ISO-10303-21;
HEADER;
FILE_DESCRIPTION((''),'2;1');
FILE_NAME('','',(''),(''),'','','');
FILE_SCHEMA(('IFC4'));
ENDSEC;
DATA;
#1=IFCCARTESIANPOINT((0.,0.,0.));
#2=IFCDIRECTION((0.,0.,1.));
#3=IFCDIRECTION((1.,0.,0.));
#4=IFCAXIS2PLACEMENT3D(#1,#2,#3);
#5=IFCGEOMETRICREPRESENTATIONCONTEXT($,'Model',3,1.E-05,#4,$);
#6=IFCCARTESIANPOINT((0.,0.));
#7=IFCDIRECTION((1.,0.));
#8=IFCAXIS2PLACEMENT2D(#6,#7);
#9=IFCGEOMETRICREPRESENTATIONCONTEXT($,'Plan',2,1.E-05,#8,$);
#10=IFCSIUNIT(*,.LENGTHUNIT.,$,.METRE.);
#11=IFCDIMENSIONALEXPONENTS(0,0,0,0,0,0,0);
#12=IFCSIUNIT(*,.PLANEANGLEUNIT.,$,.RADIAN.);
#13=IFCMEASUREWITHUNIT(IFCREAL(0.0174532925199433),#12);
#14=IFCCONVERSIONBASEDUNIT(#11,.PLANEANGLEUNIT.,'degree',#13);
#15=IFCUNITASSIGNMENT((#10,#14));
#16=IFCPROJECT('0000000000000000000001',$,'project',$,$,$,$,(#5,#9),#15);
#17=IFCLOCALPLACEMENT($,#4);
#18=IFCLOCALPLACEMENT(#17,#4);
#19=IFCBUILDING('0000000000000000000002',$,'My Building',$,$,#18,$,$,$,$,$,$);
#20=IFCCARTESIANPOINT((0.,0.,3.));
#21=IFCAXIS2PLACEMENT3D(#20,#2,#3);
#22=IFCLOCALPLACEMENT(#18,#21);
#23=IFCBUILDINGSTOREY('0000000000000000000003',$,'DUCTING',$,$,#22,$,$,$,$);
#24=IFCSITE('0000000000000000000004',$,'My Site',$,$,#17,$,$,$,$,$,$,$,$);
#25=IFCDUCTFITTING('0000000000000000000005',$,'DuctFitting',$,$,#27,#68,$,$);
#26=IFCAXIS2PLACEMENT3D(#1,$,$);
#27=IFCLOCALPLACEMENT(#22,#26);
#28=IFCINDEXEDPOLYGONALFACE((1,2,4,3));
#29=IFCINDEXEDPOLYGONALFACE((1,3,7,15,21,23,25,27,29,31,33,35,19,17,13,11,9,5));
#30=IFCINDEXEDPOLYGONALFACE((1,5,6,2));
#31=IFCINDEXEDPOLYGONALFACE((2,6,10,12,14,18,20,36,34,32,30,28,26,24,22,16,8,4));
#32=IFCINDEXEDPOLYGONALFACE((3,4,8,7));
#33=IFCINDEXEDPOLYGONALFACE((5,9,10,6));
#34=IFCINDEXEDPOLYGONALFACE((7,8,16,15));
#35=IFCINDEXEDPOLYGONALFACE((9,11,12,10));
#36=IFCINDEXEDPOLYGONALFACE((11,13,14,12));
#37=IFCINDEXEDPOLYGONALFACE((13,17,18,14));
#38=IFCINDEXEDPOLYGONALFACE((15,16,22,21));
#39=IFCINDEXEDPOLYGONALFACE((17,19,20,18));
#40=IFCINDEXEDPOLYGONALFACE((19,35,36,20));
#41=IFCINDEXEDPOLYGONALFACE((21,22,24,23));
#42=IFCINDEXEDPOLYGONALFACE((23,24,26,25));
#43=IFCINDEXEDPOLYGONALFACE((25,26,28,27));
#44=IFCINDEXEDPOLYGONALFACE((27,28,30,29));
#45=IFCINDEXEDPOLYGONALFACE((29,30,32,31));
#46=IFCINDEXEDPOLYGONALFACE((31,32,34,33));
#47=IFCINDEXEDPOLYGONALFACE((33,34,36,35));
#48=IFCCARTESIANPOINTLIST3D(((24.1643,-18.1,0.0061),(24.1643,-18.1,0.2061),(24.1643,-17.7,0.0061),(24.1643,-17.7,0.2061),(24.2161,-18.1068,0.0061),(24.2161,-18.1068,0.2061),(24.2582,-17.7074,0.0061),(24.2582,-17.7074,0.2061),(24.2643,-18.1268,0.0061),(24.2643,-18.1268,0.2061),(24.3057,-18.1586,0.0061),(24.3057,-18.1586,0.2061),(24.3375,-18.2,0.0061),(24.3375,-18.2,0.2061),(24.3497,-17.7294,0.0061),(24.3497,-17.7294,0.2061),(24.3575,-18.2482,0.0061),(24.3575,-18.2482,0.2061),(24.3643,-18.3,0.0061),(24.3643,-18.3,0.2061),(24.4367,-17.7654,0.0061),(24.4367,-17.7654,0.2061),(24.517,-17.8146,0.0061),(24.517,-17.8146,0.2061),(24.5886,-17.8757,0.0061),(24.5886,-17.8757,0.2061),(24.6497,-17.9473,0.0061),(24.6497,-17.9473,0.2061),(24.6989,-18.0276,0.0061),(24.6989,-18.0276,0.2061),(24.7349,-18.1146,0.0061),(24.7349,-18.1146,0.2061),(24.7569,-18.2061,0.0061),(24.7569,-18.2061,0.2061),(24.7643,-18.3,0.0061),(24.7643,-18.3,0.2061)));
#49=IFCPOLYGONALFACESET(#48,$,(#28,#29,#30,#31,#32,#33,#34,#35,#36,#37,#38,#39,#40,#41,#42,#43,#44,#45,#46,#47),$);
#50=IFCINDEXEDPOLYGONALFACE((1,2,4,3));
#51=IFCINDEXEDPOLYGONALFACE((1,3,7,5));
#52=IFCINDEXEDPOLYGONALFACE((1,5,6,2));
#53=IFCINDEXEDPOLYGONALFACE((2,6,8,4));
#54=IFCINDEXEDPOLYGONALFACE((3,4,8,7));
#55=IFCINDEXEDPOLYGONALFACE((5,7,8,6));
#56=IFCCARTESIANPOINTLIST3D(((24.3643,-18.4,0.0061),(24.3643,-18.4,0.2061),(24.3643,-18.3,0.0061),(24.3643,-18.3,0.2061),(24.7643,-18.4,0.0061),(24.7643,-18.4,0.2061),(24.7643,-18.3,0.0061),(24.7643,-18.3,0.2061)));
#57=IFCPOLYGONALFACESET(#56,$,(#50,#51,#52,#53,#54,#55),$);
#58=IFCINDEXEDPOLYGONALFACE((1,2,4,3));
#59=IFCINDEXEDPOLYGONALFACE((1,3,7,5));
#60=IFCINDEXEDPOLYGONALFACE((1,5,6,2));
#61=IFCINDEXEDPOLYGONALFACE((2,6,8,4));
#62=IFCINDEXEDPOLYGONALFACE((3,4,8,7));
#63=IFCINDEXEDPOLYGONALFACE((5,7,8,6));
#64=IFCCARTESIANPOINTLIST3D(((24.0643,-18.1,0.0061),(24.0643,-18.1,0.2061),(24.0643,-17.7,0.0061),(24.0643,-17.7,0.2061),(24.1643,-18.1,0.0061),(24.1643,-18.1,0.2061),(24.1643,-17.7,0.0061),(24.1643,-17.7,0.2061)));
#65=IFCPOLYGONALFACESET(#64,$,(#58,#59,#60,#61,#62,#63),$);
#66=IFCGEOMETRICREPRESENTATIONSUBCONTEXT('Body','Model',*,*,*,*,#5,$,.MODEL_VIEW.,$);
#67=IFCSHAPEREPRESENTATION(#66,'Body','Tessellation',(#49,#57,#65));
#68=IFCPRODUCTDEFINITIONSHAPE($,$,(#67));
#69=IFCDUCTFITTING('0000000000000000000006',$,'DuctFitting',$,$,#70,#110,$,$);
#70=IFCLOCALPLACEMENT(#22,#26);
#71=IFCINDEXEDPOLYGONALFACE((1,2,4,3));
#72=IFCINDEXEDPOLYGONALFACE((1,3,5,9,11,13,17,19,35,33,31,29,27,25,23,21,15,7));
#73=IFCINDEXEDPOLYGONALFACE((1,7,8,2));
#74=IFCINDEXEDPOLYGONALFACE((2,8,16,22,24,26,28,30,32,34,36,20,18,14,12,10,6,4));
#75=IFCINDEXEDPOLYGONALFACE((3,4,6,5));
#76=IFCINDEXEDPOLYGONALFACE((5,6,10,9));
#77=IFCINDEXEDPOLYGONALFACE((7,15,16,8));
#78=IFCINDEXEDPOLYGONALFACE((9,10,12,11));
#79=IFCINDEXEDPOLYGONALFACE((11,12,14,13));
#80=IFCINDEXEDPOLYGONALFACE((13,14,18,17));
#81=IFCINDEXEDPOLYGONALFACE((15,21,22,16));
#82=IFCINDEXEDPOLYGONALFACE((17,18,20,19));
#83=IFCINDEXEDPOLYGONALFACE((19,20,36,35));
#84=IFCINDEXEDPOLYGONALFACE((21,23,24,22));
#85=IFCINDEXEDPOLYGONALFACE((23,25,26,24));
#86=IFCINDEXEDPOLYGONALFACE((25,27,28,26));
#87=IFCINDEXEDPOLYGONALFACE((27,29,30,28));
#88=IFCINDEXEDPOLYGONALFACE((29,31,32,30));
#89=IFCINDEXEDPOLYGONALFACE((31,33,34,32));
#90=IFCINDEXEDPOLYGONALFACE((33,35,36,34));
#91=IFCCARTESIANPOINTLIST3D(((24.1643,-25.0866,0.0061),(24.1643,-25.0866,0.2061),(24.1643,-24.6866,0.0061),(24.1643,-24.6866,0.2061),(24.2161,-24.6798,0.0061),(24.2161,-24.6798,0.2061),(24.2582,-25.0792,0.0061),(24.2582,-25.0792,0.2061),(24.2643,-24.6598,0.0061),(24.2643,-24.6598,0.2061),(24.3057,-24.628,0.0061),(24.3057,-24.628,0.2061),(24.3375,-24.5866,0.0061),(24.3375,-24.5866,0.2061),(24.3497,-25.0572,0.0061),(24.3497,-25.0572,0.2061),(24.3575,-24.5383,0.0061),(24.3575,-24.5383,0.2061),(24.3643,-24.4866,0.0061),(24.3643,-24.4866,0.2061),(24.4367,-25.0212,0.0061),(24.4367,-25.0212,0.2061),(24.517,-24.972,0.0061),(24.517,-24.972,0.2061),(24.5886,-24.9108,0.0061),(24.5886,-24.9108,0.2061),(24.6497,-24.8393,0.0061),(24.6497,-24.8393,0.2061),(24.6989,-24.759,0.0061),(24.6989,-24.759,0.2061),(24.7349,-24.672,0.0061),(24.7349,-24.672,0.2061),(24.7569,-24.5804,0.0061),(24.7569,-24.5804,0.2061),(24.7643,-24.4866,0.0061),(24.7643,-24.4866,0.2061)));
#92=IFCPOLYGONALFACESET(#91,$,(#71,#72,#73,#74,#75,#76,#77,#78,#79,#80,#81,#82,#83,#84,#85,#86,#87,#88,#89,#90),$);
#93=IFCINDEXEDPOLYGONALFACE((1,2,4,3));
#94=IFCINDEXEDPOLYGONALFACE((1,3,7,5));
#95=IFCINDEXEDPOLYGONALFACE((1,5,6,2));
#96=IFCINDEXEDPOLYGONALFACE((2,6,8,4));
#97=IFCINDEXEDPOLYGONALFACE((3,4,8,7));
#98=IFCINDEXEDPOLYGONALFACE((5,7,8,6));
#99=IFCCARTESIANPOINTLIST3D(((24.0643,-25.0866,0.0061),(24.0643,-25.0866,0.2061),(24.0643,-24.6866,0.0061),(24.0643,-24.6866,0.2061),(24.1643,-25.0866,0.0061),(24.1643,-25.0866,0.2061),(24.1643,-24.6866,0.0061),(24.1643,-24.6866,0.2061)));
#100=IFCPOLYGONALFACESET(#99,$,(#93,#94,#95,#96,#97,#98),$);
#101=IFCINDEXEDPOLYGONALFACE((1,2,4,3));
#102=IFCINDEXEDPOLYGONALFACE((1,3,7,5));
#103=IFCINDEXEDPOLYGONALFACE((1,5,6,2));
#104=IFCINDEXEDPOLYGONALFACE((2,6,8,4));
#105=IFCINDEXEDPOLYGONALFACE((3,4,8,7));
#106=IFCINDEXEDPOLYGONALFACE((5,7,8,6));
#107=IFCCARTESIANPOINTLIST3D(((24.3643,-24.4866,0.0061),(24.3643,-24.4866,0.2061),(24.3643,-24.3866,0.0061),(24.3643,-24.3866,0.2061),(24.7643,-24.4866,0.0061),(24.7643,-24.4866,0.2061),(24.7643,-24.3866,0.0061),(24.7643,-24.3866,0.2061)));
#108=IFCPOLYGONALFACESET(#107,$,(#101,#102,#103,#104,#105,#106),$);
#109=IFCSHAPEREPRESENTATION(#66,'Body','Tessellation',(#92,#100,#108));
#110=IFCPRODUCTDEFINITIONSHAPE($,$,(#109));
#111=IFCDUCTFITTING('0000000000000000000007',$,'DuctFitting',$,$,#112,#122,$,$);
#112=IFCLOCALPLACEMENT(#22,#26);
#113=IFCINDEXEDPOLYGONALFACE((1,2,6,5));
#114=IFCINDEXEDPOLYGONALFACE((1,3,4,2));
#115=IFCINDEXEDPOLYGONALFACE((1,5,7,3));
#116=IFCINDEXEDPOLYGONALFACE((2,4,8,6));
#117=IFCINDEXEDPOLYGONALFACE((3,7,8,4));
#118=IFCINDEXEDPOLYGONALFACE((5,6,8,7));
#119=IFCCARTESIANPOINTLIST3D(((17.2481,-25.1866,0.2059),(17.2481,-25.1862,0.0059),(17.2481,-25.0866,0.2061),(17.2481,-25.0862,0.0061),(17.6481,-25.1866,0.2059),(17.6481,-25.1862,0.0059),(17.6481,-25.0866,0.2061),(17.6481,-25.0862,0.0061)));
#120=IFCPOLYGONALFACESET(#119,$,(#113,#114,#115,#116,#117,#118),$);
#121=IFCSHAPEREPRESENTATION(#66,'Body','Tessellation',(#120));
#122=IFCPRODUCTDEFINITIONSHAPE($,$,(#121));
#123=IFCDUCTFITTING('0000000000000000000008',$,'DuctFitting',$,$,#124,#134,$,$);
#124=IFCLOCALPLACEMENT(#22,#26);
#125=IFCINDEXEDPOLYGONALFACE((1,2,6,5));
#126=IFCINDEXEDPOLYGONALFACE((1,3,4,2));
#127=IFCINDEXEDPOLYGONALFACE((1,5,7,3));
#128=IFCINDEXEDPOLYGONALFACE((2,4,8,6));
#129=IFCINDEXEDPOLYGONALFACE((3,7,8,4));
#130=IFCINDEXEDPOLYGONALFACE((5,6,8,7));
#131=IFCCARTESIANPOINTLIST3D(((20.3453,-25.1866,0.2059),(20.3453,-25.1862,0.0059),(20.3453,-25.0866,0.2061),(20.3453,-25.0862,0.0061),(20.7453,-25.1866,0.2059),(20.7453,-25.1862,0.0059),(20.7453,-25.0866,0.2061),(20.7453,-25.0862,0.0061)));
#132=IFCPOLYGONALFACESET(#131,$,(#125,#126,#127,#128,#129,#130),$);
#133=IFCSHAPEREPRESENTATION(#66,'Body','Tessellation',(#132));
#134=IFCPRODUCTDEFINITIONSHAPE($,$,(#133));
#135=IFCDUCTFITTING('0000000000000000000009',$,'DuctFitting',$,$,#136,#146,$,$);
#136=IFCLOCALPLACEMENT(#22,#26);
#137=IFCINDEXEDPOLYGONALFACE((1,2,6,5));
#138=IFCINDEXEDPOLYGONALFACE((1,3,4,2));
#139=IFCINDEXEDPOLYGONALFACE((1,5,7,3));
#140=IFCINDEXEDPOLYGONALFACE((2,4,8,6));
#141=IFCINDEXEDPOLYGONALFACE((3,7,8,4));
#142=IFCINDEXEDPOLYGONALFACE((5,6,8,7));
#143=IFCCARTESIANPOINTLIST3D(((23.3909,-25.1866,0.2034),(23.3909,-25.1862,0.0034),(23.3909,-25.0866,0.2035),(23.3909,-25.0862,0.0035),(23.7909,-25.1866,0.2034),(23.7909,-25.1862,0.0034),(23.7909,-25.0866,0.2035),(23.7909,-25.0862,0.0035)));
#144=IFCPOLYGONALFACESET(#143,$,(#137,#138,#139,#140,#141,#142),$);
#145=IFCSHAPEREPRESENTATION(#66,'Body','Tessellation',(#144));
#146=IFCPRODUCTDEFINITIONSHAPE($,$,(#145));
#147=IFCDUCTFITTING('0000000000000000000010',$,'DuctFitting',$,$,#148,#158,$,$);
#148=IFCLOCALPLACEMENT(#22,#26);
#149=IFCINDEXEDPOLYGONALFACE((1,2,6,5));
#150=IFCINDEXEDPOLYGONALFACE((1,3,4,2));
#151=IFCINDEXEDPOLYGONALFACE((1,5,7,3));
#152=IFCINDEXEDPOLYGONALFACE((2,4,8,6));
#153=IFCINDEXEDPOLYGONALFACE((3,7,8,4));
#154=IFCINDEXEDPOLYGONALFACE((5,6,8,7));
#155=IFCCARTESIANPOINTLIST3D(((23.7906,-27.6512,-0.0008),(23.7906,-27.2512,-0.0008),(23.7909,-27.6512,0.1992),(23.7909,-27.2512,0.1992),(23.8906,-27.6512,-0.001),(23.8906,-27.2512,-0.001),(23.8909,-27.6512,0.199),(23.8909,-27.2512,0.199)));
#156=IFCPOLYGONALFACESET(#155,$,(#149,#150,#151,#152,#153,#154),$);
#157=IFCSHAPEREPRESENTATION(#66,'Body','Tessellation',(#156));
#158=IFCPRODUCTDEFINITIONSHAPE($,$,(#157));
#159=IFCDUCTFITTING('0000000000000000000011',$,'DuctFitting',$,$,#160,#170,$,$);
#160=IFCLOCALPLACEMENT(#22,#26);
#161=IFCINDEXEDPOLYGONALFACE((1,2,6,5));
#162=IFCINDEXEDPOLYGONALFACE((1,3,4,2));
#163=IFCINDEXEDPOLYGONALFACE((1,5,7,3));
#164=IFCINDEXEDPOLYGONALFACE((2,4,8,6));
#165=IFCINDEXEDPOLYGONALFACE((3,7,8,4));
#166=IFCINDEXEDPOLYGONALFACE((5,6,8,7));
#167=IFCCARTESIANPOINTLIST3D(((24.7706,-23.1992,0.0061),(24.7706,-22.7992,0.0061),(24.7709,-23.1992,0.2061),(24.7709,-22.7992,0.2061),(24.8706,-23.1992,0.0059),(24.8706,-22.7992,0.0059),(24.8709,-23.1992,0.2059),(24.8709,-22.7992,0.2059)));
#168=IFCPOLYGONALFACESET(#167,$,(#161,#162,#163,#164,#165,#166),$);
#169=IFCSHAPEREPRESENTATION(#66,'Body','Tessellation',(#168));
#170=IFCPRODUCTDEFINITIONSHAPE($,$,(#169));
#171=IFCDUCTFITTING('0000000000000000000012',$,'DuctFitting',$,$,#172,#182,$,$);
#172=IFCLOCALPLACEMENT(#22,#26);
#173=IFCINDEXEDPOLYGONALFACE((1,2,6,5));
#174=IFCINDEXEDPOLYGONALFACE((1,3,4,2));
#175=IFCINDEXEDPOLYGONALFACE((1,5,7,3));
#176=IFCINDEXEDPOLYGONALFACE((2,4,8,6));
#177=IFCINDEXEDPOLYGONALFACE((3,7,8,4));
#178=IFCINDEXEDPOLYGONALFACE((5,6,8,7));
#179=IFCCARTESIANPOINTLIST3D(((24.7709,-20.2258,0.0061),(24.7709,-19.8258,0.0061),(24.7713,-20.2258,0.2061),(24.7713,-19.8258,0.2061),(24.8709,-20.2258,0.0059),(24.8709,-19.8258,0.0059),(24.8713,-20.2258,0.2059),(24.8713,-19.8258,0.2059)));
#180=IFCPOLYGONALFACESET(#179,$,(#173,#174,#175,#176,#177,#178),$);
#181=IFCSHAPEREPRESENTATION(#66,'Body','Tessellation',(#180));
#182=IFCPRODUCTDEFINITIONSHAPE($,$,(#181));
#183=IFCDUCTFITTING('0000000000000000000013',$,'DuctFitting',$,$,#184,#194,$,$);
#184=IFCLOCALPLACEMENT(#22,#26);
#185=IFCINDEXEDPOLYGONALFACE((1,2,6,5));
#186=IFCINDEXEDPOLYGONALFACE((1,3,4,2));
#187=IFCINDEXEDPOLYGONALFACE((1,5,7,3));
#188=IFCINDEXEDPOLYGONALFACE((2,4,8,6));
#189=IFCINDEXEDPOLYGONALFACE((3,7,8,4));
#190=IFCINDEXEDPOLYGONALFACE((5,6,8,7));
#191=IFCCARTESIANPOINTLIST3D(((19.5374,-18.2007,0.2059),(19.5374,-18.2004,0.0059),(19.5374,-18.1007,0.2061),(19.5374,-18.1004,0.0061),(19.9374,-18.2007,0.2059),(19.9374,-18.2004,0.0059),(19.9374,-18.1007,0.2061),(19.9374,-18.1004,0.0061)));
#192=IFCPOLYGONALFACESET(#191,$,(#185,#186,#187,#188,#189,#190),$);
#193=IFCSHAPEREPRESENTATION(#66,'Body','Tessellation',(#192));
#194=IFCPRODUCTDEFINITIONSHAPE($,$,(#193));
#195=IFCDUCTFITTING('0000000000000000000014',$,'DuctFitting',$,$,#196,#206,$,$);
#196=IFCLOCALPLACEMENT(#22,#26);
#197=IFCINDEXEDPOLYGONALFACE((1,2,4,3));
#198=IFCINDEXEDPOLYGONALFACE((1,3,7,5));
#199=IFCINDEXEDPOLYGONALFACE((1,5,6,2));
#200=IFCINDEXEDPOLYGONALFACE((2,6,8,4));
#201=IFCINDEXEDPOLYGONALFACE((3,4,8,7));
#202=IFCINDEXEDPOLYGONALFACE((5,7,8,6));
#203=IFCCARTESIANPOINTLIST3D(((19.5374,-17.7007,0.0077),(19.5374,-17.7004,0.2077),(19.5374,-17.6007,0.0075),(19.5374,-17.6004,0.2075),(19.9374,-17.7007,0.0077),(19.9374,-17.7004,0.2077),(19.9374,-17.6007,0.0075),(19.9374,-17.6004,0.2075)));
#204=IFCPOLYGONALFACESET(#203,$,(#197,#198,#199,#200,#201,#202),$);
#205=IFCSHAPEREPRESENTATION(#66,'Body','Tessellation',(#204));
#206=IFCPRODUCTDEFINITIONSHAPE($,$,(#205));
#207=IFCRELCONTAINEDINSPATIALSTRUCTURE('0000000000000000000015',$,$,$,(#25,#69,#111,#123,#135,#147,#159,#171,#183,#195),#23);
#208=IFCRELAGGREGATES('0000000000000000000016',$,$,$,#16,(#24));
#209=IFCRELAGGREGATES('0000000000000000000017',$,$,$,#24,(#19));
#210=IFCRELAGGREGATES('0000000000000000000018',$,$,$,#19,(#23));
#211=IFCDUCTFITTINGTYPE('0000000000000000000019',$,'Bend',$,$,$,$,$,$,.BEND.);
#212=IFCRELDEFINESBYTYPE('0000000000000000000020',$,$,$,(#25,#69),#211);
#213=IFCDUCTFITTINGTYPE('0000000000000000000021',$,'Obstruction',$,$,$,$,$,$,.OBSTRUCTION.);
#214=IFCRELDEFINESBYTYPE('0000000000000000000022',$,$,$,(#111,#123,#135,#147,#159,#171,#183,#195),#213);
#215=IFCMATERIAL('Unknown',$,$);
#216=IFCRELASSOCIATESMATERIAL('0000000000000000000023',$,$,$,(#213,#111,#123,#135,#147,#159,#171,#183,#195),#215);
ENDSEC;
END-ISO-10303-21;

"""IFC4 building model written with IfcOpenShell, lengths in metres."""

from ifc_helpers import new_model, entity, si_unit, converted_unit, frame, origin_with_axes, origin_2d_with_axis, place, context, subcontext, project, spatial, line, arc, indexed_curve, rectangle, outline, extrude, source, transform, mapped, material, material_profile, profile_set, profile_usage, type_object, type_shapes, element, save


model = new_model("IFC4")

# Units and contexts
model_context = context("Model", 3, precision=1e-05, world=origin_with_axes())
plan_context = context("Plan", 2, precision=1e-05, world=origin_2d_with_axis())
body_context = subcontext(model_context, "Body", "Model", "MODEL_VIEW")
ifc_project = project(units=[si_unit("LENGTHUNIT", "METRE"), converted_unit("PLANEANGLEUNIT", "degree", entity("IfcReal", 0.0174532925199433), si_unit("PLANEANGLEUNIT", "RADIAN"), dimensions=[0, 0, 0, 0, 0, 0, 0])], contexts=[model_context, plan_context])

# Site, building, storey
site_placement = place(None, origin_with_axes())
site = spatial("IfcSite", under=ifc_project, at=site_placement, Name="My Site")
building_placement = place(site_placement, origin_with_axes())
building = spatial("IfcBuilding", under=site, at=building_placement, Name="My Building")
storey_placement = place(building_placement, frame((0.0, 0.0, 3.0), z_axis=(0.0, 0.0, 1.0), x_axis=(1.0, 0.0, 0.0)))
storey = spatial("IfcBuildingStorey", under=building, at=storey_placement, Name="DUCTING")

# Shared definitions
ifc_material = material(Name="Unknown")

# Duct fittings
duct_fitting_type_1 = type_object("IfcDuctFittingType", Name="Bend", PredefinedType="BEND")
shared_shape = source(origin_with_axes(), body_context, "Body", "SweptSolid", [
    extrude(outline(indexed_curve([(-0.2, 0.0), (-0.2586, -0.1414), (-0.4, -0.2), (-0.4, -0.6), (0.0243, -0.4243), (0.2, 0.0)], segments=[arc(1, 2, 3), line(3, 4), arc(4, 5, 6), line(6, 1)])), frame((0.0, -0.1, -0.1), z_axis=(0.0, -1.0, 0.0), x_axis=(1.0, 0.0, 0.0)), (0.0, 0.0, -1.0), 0.2),
    extrude(rectangle(XDim=0.4, YDim=0.2), origin_with_axes(), (0.0, 0.0, -1.0), 0.1),
    extrude(rectangle(XDim=0.4, YDim=0.2), frame((-0.4, 0.0, -0.5), z_axis=(-1.0, 0.0, 0.0), x_axis=(0.0, 0.0, -1.0)), (0.0, 0.0, 1.0), 0.1),
])
type_shapes(duct_fitting_type_1, [shared_shape])
for number, where, z_axis, x_axis, name in (
    (1, (24.5643, -18.4, 0.1061), (0.0, -1.0, 0.0), (1.0, 0.0, 0.0), "DuctFitting"),
    (2, (24.0643, -24.8866, 0.1061), (-1.0, 0.0, 0.0), (0.0, -1.0, 0.0), "DuctFitting"),
):
    element("IfcDuctFitting", number, at=place(storey_placement, frame(where, z_axis=z_axis, x_axis=x_axis)), inside=storey, type_object=duct_fitting_type_1, Name=name, context=body_context, shape_type="MappedRepresentation", body=[
        mapped(shared_shape, transform((0.0, 0.0, 0.0), x_axis=(1.0, 0.0, 0.0), y_axis=(0.0, 1.0, 0.0), z_axis=(0.0, 0.0, 1.0), scale=1.0)),
    ])
ifc_material_profile_1 = material_profile(ifc_material, rectangle(XDim=0.4, YDim=0.2))
ifc_profile_set_1 = profile_set([ifc_material_profile_1])
ifc_profile_usage_1 = profile_usage(ifc_profile_set_1, cardinal=5)
duct_fitting_type_2 = type_object("IfcDuctFittingType", Name="Obstruction", PredefinedType="OBSTRUCTION", material=ifc_profile_set_1)
duct_fitting_1_placement = place(storey_placement, frame((17.4481, -25.0864, 0.1061), z_axis=(0.0, -0.999998, -0.001745), x_axis=(1.0, 0.0, 0.0)))
element("IfcDuctFitting", 3, at=duct_fitting_1_placement, inside=storey, type_object=duct_fitting_type_2, material=ifc_profile_usage_1, Name="DuctFitting", context=body_context, shape_type="SweptSolid", body=[
    extrude(rectangle(XDim=0.4, YDim=0.2), origin_with_axes(), (0.0, 0.0, 1.0), 0.1),
])
ifc_profile_usage_2 = profile_usage(ifc_profile_set_1, cardinal=5)
duct_fitting_2_placement = place(storey_placement, frame((20.5453, -25.0864, 0.1061), z_axis=(0.0, -0.999998, -0.001745), x_axis=(1.0, 0.0, 0.0)))
element("IfcDuctFitting", 4, at=duct_fitting_2_placement, inside=storey, type_object=duct_fitting_type_2, material=ifc_profile_usage_2, Name="DuctFitting", context=body_context, shape_type="SweptSolid", body=[
    extrude(rectangle(XDim=0.4, YDim=0.2), origin_with_axes(), (0.0, 0.0, 1.0), 0.1),
])
ifc_profile_usage_3 = profile_usage(ifc_profile_set_1, cardinal=5)
duct_fitting_3_placement = place(storey_placement, frame((23.5909, -25.0864, 0.1035), z_axis=(0.0, -0.999998, -0.001745), x_axis=(1.0, 0.0, 0.0)))
element("IfcDuctFitting", 5, at=duct_fitting_3_placement, inside=storey, type_object=duct_fitting_type_2, material=ifc_profile_usage_3, Name="DuctFitting", context=body_context, shape_type="SweptSolid", body=[
    extrude(rectangle(XDim=0.4, YDim=0.2), origin_with_axes(), (0.0, 0.0, 1.0), 0.1),
])
ifc_profile_usage_4 = profile_usage(ifc_profile_set_1, cardinal=5)
duct_fitting_4_placement = place(storey_placement, frame((23.7907, -27.4512, 0.0992), z_axis=(0.999998, 0.0, -0.001745), x_axis=(0.0, 1.0, 0.0)))
element("IfcDuctFitting", 6, at=duct_fitting_4_placement, inside=storey, type_object=duct_fitting_type_2, material=ifc_profile_usage_4, Name="DuctFitting", context=body_context, shape_type="SweptSolid", body=[
    extrude(rectangle(XDim=0.4, YDim=0.2), origin_with_axes(), (0.0, 0.0, 1.0), 0.1),
])
ifc_profile_usage_5 = profile_usage(ifc_profile_set_1, cardinal=5)
duct_fitting_5_placement = place(storey_placement, frame((24.7707, -22.9992, 0.1061), z_axis=(0.999998, 0.0, -0.001745), x_axis=(0.0, 1.0, 0.0)))
element("IfcDuctFitting", 7, at=duct_fitting_5_placement, inside=storey, type_object=duct_fitting_type_2, material=ifc_profile_usage_5, Name="DuctFitting", context=body_context, shape_type="SweptSolid", body=[
    extrude(rectangle(XDim=0.4, YDim=0.2), origin_with_axes(), (0.0, 0.0, 1.0), 0.1),
])
ifc_profile_usage_6 = profile_usage(ifc_profile_set_1, cardinal=5)
duct_fitting_6_placement = place(storey_placement, frame((24.7711, -20.0258, 0.1061), z_axis=(0.999998, 0.0, -0.001745), x_axis=(0.0, 1.0, 0.0)))
element("IfcDuctFitting", 8, at=duct_fitting_6_placement, inside=storey, type_object=duct_fitting_type_2, material=ifc_profile_usage_6, Name="DuctFitting", context=body_context, shape_type="SweptSolid", body=[
    extrude(rectangle(XDim=0.4, YDim=0.2), origin_with_axes(), (0.0, 0.0, 1.0), 0.1),
])
ifc_profile_usage_7 = profile_usage(ifc_profile_set_1, cardinal=5)
duct_fitting_7_placement = place(storey_placement, frame((19.7374, -18.1005, 0.1061), z_axis=(0.0, -0.999998, -0.001745), x_axis=(1.0, 0.0, 0.0)))
element("IfcDuctFitting", 9, at=duct_fitting_7_placement, inside=storey, type_object=duct_fitting_type_2, material=ifc_profile_usage_7, Name="DuctFitting", context=body_context, shape_type="SweptSolid", body=[
    extrude(rectangle(XDim=0.4, YDim=0.2), origin_with_axes(), (0.0, 0.0, 1.0), 0.1),
])
ifc_profile_usage_8 = profile_usage(ifc_profile_set_1, cardinal=5)
duct_fitting_8_placement = place(storey_placement, frame((19.7374, -17.7006, 0.1077), z_axis=(0.0, 0.999998, -0.001745), x_axis=(-1.0, 0.0, 0.0)))
element("IfcDuctFitting", 10, at=duct_fitting_8_placement, inside=storey, type_object=duct_fitting_type_2, material=ifc_profile_usage_8, Name="DuctFitting", context=body_context, shape_type="SweptSolid", body=[
    extrude(rectangle(XDim=0.4, YDim=0.2), origin_with_axes(), (0.0, 0.0, 1.0), 0.1),
])

save(model, "model.ifc")
